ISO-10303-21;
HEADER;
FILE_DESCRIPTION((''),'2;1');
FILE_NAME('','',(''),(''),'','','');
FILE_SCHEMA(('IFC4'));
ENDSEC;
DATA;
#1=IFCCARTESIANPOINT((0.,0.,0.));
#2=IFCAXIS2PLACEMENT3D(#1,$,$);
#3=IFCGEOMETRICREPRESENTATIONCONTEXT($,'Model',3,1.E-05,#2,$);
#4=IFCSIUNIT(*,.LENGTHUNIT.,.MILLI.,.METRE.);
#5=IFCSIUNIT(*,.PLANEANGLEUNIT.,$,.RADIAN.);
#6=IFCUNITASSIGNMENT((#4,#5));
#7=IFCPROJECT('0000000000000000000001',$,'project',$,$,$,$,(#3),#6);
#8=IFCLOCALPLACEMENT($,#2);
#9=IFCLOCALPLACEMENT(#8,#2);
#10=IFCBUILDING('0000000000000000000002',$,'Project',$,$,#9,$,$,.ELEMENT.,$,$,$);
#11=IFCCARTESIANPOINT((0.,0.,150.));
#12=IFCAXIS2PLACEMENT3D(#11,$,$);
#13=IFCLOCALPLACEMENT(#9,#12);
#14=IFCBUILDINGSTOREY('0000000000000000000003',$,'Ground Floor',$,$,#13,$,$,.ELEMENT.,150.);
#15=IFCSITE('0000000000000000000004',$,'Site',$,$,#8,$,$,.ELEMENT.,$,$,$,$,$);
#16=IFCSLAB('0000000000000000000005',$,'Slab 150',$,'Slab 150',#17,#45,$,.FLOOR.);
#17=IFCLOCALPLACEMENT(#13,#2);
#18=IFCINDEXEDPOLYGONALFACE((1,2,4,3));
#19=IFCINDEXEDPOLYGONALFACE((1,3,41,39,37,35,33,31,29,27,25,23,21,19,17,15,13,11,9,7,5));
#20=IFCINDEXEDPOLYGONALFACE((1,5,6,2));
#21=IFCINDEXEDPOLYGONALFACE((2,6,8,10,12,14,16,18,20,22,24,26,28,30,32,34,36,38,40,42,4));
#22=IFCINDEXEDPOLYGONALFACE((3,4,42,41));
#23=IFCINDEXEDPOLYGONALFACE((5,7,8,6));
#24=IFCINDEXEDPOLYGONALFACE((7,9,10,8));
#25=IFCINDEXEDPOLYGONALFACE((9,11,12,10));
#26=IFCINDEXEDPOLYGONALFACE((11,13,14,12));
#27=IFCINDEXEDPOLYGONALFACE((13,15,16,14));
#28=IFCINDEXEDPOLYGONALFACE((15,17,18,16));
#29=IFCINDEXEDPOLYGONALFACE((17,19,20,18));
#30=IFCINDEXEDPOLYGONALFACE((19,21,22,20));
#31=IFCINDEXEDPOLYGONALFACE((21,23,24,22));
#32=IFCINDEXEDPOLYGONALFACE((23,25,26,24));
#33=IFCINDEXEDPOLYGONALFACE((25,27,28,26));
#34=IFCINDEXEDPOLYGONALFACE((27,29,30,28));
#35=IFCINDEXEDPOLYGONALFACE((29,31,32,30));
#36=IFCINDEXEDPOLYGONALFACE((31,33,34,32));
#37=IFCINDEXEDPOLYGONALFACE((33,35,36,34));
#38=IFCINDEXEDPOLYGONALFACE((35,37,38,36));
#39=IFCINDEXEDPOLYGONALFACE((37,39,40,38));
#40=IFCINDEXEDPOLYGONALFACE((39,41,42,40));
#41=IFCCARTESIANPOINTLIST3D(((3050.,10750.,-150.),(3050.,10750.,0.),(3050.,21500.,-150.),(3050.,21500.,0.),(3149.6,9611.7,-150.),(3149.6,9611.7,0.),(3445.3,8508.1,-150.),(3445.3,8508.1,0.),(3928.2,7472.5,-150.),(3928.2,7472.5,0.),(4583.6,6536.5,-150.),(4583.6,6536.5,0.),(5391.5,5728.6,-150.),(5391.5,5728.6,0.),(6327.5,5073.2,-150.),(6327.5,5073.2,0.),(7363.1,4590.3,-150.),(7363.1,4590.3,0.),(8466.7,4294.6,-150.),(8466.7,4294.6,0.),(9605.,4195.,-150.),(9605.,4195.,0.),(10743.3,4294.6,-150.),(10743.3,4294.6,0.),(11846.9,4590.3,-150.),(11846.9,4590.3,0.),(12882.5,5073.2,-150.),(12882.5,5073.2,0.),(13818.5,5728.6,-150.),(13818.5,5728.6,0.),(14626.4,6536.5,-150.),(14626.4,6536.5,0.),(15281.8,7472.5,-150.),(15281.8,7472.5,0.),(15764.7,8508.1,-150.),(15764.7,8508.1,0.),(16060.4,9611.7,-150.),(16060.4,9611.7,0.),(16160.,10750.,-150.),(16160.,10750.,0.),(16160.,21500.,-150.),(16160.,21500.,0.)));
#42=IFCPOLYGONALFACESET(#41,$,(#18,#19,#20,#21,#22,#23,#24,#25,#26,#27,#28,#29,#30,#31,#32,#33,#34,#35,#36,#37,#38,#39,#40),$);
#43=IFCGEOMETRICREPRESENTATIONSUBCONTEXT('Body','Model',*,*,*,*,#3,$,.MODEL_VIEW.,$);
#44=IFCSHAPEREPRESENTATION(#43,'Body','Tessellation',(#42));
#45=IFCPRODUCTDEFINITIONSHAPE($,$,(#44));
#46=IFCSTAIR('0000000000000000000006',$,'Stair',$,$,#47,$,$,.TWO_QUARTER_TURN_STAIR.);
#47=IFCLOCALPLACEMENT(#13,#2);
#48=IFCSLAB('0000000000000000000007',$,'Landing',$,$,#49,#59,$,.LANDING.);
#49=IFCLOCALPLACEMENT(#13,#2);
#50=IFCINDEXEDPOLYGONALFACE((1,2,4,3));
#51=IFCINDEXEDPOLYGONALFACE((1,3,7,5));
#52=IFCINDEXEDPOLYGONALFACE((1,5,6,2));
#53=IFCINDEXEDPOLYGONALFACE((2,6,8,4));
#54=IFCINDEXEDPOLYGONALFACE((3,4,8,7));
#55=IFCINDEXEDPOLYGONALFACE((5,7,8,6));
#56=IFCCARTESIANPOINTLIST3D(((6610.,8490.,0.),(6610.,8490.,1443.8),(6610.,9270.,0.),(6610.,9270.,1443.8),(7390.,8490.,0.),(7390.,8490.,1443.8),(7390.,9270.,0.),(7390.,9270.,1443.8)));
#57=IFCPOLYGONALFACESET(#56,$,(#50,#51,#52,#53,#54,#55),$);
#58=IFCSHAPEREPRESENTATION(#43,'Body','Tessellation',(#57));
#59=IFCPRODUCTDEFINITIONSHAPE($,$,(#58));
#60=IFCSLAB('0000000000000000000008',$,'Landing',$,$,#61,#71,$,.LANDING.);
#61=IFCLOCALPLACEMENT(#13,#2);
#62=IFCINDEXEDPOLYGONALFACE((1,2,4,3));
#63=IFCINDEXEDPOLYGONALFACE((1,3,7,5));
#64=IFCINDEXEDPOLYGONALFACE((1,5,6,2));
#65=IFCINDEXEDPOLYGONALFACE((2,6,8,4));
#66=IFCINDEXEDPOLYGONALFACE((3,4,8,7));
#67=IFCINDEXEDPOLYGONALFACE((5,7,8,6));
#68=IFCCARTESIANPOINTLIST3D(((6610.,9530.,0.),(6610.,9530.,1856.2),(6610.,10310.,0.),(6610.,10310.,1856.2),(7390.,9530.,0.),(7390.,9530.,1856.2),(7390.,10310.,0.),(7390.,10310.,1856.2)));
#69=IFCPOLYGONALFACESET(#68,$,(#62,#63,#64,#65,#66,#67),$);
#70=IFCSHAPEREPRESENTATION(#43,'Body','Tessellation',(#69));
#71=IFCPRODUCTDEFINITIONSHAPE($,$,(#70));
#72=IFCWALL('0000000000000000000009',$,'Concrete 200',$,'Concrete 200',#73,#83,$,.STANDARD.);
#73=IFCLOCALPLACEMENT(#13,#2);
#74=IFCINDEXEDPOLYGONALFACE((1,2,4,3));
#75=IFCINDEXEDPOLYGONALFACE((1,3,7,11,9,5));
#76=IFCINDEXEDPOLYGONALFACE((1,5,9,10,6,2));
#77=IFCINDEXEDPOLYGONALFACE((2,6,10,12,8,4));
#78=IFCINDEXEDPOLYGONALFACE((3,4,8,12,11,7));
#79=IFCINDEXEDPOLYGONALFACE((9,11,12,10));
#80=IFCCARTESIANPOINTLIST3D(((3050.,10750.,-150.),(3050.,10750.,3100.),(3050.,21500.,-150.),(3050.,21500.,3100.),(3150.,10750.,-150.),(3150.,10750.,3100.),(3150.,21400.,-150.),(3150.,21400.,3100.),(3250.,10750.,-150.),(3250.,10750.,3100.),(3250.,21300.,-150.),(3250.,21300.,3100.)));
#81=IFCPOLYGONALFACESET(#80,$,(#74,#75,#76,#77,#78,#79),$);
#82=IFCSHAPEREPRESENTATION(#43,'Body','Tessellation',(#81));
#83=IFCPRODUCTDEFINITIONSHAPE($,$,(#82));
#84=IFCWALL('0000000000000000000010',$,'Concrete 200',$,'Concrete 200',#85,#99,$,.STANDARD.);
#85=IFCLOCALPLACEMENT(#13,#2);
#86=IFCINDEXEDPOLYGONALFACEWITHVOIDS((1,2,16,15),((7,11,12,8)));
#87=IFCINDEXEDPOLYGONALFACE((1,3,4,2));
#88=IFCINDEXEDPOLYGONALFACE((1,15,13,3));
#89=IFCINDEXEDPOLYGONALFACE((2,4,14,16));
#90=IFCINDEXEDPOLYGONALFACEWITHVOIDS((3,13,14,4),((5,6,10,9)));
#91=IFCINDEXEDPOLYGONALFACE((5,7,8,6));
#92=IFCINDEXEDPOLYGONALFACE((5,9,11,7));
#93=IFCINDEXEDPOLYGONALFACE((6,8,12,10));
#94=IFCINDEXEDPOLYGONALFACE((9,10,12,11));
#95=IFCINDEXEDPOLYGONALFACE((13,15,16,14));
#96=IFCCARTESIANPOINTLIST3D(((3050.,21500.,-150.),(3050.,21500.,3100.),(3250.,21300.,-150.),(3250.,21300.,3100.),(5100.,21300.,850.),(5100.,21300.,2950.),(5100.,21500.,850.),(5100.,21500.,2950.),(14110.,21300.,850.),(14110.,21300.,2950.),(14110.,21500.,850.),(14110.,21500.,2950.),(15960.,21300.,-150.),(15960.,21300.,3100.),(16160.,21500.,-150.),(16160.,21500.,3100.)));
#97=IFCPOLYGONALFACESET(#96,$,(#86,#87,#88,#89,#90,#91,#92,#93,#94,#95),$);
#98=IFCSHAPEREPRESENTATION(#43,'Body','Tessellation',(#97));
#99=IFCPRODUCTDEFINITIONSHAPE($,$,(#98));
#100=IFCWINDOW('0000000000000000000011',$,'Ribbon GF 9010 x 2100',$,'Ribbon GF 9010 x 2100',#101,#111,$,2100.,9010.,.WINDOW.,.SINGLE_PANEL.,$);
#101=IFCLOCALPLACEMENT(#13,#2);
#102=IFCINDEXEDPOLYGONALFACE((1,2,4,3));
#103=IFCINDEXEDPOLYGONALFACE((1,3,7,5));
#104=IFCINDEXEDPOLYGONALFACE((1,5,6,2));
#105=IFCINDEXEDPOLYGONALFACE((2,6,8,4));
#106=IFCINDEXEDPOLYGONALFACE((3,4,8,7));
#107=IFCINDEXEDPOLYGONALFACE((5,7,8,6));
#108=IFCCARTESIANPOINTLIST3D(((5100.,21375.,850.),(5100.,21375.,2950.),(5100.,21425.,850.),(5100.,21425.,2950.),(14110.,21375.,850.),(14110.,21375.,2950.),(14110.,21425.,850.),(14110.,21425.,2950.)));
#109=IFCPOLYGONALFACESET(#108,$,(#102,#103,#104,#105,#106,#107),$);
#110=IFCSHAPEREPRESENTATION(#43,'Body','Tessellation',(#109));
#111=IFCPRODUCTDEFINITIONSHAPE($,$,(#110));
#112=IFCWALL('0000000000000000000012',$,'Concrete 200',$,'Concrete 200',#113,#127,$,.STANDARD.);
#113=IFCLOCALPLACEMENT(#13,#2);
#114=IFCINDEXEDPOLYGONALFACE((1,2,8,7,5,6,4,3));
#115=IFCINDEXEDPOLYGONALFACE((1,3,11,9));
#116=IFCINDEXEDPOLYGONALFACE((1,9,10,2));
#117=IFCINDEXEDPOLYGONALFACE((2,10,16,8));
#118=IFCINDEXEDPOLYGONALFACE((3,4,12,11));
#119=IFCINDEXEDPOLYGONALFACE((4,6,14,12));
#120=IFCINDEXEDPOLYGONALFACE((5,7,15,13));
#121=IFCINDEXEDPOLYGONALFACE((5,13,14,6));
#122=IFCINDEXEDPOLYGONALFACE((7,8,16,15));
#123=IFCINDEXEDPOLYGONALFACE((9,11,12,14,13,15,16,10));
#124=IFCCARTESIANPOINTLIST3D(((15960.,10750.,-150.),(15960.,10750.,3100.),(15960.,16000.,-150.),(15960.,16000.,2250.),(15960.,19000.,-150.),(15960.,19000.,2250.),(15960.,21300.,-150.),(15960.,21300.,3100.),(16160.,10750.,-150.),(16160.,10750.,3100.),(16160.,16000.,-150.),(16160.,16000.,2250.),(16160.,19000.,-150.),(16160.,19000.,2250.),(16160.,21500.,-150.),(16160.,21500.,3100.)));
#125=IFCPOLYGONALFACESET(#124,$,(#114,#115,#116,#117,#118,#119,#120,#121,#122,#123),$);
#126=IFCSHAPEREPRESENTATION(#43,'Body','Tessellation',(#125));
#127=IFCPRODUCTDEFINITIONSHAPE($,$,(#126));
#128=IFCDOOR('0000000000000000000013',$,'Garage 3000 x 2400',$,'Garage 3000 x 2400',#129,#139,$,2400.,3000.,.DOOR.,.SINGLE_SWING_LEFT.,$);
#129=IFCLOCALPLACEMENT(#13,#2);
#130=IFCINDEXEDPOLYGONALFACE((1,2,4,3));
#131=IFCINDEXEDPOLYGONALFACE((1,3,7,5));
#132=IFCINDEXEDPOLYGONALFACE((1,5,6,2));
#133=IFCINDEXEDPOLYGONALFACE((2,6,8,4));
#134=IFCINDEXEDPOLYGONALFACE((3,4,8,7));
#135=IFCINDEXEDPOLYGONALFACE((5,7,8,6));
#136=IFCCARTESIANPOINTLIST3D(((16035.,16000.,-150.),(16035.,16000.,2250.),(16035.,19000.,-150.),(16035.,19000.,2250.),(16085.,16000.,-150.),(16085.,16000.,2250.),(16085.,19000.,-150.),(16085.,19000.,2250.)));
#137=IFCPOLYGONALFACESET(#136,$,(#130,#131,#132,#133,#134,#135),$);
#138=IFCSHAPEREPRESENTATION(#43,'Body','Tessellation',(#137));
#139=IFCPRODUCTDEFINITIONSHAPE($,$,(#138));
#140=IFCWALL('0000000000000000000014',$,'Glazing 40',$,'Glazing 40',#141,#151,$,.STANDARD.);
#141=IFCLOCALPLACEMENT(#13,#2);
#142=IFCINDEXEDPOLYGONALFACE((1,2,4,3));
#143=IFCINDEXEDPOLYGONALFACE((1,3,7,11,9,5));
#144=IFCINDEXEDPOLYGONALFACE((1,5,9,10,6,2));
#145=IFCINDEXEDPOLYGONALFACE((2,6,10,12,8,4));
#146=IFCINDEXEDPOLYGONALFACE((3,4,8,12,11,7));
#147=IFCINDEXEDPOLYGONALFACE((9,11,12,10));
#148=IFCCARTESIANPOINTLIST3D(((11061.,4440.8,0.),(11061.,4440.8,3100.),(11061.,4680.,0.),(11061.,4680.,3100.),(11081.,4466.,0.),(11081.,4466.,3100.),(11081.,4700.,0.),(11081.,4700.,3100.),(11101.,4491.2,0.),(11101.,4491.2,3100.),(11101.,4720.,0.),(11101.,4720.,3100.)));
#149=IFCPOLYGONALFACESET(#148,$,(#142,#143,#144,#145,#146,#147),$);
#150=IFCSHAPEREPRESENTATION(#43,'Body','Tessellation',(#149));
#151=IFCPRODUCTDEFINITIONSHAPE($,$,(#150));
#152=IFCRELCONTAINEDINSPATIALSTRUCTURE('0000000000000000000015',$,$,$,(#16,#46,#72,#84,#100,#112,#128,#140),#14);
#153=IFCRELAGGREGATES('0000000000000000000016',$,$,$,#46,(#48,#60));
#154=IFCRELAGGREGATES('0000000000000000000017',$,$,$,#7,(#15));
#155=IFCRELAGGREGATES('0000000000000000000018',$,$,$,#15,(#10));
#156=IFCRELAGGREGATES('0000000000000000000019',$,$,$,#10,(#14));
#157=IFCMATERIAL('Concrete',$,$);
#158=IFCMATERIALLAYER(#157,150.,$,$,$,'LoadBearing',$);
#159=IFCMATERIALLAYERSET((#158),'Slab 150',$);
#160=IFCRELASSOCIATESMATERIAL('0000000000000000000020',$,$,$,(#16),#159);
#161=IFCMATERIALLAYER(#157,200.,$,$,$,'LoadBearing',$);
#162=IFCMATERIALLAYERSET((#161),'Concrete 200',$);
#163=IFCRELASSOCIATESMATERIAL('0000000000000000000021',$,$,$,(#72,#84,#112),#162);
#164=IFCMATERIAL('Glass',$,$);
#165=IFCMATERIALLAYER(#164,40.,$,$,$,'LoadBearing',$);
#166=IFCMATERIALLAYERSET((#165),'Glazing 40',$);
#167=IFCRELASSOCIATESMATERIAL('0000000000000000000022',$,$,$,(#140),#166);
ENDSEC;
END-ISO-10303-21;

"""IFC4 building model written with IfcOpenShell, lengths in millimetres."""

from ifc_helpers import new_model, si_unit, frame, frame_2d, origin, place, context, subcontext, project, spatial, polyline, rectangle, outline, extrude, material, layer, layer_set, layer_usage, element, fill, aggregate, save


model = new_model("IFC4")

# Units and contexts
model_context = context("Model", 3, precision=1e-05, world=origin())
body_context = subcontext(model_context, "Body", "Model", "MODEL_VIEW")
ifc_project = project(units=[si_unit("LENGTHUNIT", "METRE", prefix="MILLI"), si_unit("PLANEANGLEUNIT", "RADIAN")], contexts=[model_context])

# Site, building, storey
site_placement = place(None, origin())
site = spatial("IfcSite", under=ifc_project, at=site_placement, Name="Site", CompositionType="ELEMENT")
building_placement = place(site_placement, origin())
building = spatial("IfcBuilding", under=site, at=building_placement, Name="Project", CompositionType="ELEMENT")
storey_placement = place(building_placement, frame((0.0, 0.0, 150.0)))
storey = spatial("IfcBuildingStorey", under=building, at=storey_placement, Name="Ground Floor", CompositionType="ELEMENT", Elevation=150.0)

# Slab
ifc_material_1 = material(Name="Concrete")
ifc_layer_1 = layer(ifc_material_1, 150.0, Category="LoadBearing")
ifc_layer_set_1 = layer_set([ifc_layer_1], Name="Slab 150")
ifc_layer_usage_1 = layer_usage(ifc_layer_set_1, "AXIS3", "NEGATIVE", 0.0)
slab_1_placement = place(storey_placement, origin())
element("IfcSlab", 1, at=slab_1_placement, inside=storey, material=ifc_layer_usage_1, Name="Slab 150", ObjectType="Slab 150", PredefinedType="FLOOR", context=body_context, shape_type="SweptSolid", body=[
    extrude(outline(polyline([(3050.0, 10750.0), (3149.6, 9611.7), (3445.3, 8508.1), (3928.2, 7472.5), (4583.6, 6536.5), (5391.5, 5728.6), (6327.5, 5073.2), (7363.1, 4590.3), (8466.7, 4294.6), (9605.0, 4195.0), (10743.3, 4294.6), (11846.9, 4590.3), (12882.5, 5073.2), (13818.5, 5728.6), (14626.4, 6536.5), (15281.8, 7472.5), (15764.7, 8508.1), (16060.4, 9611.7), (16160.0, 10750.0), (16160.0, 21500.0), (3050.0, 21500.0), (3050.0, 10750.0)])), frame((0.0, 0.0, -150.0)), (0.0, 0.0, 1.0), 150.0),
])

# Stair, slabs
stair_placement = place(storey_placement, origin())
stair = element("IfcStair", 2, at=stair_placement, inside=storey, Name="Stair", PredefinedType="TWO_QUARTER_TURN_STAIR")
slab_2_placement = place(stair_placement, origin())
slab_2 = element("IfcSlab", 3, at=slab_2_placement, Name="Landing", PredefinedType="LANDING", context=body_context, shape_type="SweptSolid", body=[
    extrude(outline(polyline([(6610.0, 8490.0), (7390.0, 8490.0), (7390.0, 9270.0), (6610.0, 9270.0), (6610.0, 8490.0)])), origin(), (0.0, 0.0, 1.0), 1443.8),
])
slab_3_placement = place(stair_placement, origin())
slab_3 = element("IfcSlab", 4, at=slab_3_placement, Name="Landing", PredefinedType="LANDING", context=body_context, shape_type="SweptSolid", body=[
    extrude(outline(polyline([(7390.0, 9530.0), (7390.0, 10310.0), (6610.0, 10310.0), (6610.0, 9530.0), (7390.0, 9530.0)])), origin(), (0.0, 0.0, 1.0), 1856.2),
])

# Wall
ifc_layer_2 = layer(ifc_material_1, 200.0, Category="LoadBearing")
ifc_layer_set_2 = layer_set([ifc_layer_2], Name="Concrete 200")
ifc_layer_usage_2 = layer_usage(ifc_layer_set_2, "AXIS2", "NEGATIVE", 100.0)
wall_1_placement = place(storey_placement, frame((3150.0, 10750.0, -150.0), z_axis=(0.0, 0.0, 1.0), x_axis=(0.0, 1.0, 0.0)))
element("IfcWall", 5, at=wall_1_placement, inside=storey, material=ifc_layer_usage_2, Name="Concrete 200", ObjectType="Concrete 200", PredefinedType="STANDARD", context=body_context, shape_type="SweptSolid", body=[
    extrude(outline(polyline([(0.0, -100.0), (0.0, 0.0), (0.0, 100.0), (10750.0, 100.0), (10650.0, 0.0), (10550.0, -100.0), (0.0, -100.0)])), origin(), (0.0, 0.0, 1.0), 3250.0),
])

# Wall, opening, window
wall_2_placement = place(storey_placement, frame((3150.0, 21400.0, -150.0), z_axis=(0.0, 0.0, 1.0), x_axis=(1.0, 0.0, 0.0)))
wall_2 = element("IfcWall", 6, at=wall_2_placement, inside=storey, material=ifc_layer_usage_2, Name="Concrete 200", ObjectType="Concrete 200", PredefinedType="STANDARD", context=body_context, shape_type="SweptSolid", body=[
    extrude(outline(polyline([(100.0, -100.0), (0.0, 0.0), (-100.0, 100.0), (13010.0, 100.0), (12910.0, 0.0), (12810.0, -100.0), (100.0, -100.0)])), origin(), (0.0, 0.0, 1.0), 3250.0),
])
opening_1_placement = place(wall_2_placement, frame((1950.0, 0.0, 1000.0), z_axis=(0.0, 0.0, 1.0), x_axis=(1.0, 0.0, 0.0)))
opening_1 = element("IfcOpeningElement", 7, at=opening_1_placement, cuts=wall_2, PredefinedType="OPENING", context=body_context, shape_type="SweptSolid", body=[
    extrude(rectangle(XDim=9010.0, YDim=220.0, at=frame_2d((4505.0, 0.0))), origin(), (0.0, 0.0, 1.0), 2100.0),
])
window_placement = place(opening_1_placement, origin())
window = element("IfcWindow", 8, at=window_placement, inside=storey, Name="Ribbon GF 9010 x 2100", ObjectType="Ribbon GF 9010 x 2100", OverallHeight=2100.0, OverallWidth=9010.0, PartitioningType="SINGLE_PANEL", PredefinedType="WINDOW", context=body_context, shape_type="SweptSolid", body=[
    extrude(rectangle(XDim=9010.0, YDim=50.0, at=frame_2d((4505.0, 0.0))), origin(), (0.0, 0.0, 1.0), 2100.0),
])
fill(opening_1, window)

# Wall, opening, door
wall_3_placement = place(storey_placement, frame((16060.0, 21400.0, -150.0), z_axis=(0.0, 0.0, 1.0), x_axis=(0.0, -1.0, 0.0)))
wall_3 = element("IfcWall", 9, at=wall_3_placement, inside=storey, material=ifc_layer_usage_2, Name="Concrete 200", ObjectType="Concrete 200", PredefinedType="STANDARD", context=body_context, shape_type="SweptSolid", body=[
    extrude(outline(polyline([(100.0, -100.0), (0.0, 0.0), (-100.0, 100.0), (10650.0, 100.0), (10650.0, 0.0), (10650.0, -100.0), (100.0, -100.0)])), origin(), (0.0, 0.0, 1.0), 3250.0),
])
opening_2_placement = place(wall_3_placement, frame((2400.0, 0.0, 0.0), z_axis=(0.0, 0.0, 1.0), x_axis=(1.0, 0.0, 0.0)))
opening_2 = element("IfcOpeningElement", 10, at=opening_2_placement, cuts=wall_3, PredefinedType="OPENING", context=body_context, shape_type="SweptSolid", body=[
    extrude(rectangle(XDim=3000.0, YDim=220.0, at=frame_2d((1500.0, 0.0))), origin(), (0.0, 0.0, 1.0), 2400.0),
])
door_1_placement = place(opening_2_placement, origin())
door_1 = element("IfcDoor", 11, at=door_1_placement, inside=storey, Name="Garage 3000 x 2400", ObjectType="Garage 3000 x 2400", OperationType="SINGLE_SWING_LEFT", OverallHeight=2400.0, OverallWidth=3000.0, PredefinedType="DOOR", context=body_context, shape_type="SweptSolid", body=[
    extrude(rectangle(XDim=3000.0, YDim=50.0, at=frame_2d((1500.0, 0.0))), origin(), (0.0, 0.0, 1.0), 2400.0),
])
fill(opening_2, door_1)

# Wall
ifc_material_2 = material(Name="Glass")
ifc_layer_3 = layer(ifc_material_2, 40.0, Category="LoadBearing")
ifc_layer_set_3 = layer_set([ifc_layer_3], Name="Glazing 40")
ifc_layer_usage_3 = layer_usage(ifc_layer_set_3, "AXIS2", "NEGATIVE", 20.0)
wall_4_placement = place(storey_placement, frame((11081.0, 4466.0, 0.0), z_axis=(0.0, 0.0, 1.0), x_axis=(0.0, 1.0, 0.0)))
element("IfcWall", 12, at=wall_4_placement, inside=storey, material=ifc_layer_usage_3, Name="Glazing 40", ObjectType="Glazing 40", PredefinedType="STANDARD", context=body_context, shape_type="SweptSolid", body=[
    extrude(outline(polyline([(25.2, -20.0), (0.0, 0.0), (-25.2, 20.0), (214.0, 20.0), (234.0, 0.0), (254.0, -20.0), (25.2, -20.0)])), origin(), (0.0, 0.0, 1.0), 3100.0),
])

aggregate(stair, [slab_2, slab_3])

save(model, "model.ifc")
